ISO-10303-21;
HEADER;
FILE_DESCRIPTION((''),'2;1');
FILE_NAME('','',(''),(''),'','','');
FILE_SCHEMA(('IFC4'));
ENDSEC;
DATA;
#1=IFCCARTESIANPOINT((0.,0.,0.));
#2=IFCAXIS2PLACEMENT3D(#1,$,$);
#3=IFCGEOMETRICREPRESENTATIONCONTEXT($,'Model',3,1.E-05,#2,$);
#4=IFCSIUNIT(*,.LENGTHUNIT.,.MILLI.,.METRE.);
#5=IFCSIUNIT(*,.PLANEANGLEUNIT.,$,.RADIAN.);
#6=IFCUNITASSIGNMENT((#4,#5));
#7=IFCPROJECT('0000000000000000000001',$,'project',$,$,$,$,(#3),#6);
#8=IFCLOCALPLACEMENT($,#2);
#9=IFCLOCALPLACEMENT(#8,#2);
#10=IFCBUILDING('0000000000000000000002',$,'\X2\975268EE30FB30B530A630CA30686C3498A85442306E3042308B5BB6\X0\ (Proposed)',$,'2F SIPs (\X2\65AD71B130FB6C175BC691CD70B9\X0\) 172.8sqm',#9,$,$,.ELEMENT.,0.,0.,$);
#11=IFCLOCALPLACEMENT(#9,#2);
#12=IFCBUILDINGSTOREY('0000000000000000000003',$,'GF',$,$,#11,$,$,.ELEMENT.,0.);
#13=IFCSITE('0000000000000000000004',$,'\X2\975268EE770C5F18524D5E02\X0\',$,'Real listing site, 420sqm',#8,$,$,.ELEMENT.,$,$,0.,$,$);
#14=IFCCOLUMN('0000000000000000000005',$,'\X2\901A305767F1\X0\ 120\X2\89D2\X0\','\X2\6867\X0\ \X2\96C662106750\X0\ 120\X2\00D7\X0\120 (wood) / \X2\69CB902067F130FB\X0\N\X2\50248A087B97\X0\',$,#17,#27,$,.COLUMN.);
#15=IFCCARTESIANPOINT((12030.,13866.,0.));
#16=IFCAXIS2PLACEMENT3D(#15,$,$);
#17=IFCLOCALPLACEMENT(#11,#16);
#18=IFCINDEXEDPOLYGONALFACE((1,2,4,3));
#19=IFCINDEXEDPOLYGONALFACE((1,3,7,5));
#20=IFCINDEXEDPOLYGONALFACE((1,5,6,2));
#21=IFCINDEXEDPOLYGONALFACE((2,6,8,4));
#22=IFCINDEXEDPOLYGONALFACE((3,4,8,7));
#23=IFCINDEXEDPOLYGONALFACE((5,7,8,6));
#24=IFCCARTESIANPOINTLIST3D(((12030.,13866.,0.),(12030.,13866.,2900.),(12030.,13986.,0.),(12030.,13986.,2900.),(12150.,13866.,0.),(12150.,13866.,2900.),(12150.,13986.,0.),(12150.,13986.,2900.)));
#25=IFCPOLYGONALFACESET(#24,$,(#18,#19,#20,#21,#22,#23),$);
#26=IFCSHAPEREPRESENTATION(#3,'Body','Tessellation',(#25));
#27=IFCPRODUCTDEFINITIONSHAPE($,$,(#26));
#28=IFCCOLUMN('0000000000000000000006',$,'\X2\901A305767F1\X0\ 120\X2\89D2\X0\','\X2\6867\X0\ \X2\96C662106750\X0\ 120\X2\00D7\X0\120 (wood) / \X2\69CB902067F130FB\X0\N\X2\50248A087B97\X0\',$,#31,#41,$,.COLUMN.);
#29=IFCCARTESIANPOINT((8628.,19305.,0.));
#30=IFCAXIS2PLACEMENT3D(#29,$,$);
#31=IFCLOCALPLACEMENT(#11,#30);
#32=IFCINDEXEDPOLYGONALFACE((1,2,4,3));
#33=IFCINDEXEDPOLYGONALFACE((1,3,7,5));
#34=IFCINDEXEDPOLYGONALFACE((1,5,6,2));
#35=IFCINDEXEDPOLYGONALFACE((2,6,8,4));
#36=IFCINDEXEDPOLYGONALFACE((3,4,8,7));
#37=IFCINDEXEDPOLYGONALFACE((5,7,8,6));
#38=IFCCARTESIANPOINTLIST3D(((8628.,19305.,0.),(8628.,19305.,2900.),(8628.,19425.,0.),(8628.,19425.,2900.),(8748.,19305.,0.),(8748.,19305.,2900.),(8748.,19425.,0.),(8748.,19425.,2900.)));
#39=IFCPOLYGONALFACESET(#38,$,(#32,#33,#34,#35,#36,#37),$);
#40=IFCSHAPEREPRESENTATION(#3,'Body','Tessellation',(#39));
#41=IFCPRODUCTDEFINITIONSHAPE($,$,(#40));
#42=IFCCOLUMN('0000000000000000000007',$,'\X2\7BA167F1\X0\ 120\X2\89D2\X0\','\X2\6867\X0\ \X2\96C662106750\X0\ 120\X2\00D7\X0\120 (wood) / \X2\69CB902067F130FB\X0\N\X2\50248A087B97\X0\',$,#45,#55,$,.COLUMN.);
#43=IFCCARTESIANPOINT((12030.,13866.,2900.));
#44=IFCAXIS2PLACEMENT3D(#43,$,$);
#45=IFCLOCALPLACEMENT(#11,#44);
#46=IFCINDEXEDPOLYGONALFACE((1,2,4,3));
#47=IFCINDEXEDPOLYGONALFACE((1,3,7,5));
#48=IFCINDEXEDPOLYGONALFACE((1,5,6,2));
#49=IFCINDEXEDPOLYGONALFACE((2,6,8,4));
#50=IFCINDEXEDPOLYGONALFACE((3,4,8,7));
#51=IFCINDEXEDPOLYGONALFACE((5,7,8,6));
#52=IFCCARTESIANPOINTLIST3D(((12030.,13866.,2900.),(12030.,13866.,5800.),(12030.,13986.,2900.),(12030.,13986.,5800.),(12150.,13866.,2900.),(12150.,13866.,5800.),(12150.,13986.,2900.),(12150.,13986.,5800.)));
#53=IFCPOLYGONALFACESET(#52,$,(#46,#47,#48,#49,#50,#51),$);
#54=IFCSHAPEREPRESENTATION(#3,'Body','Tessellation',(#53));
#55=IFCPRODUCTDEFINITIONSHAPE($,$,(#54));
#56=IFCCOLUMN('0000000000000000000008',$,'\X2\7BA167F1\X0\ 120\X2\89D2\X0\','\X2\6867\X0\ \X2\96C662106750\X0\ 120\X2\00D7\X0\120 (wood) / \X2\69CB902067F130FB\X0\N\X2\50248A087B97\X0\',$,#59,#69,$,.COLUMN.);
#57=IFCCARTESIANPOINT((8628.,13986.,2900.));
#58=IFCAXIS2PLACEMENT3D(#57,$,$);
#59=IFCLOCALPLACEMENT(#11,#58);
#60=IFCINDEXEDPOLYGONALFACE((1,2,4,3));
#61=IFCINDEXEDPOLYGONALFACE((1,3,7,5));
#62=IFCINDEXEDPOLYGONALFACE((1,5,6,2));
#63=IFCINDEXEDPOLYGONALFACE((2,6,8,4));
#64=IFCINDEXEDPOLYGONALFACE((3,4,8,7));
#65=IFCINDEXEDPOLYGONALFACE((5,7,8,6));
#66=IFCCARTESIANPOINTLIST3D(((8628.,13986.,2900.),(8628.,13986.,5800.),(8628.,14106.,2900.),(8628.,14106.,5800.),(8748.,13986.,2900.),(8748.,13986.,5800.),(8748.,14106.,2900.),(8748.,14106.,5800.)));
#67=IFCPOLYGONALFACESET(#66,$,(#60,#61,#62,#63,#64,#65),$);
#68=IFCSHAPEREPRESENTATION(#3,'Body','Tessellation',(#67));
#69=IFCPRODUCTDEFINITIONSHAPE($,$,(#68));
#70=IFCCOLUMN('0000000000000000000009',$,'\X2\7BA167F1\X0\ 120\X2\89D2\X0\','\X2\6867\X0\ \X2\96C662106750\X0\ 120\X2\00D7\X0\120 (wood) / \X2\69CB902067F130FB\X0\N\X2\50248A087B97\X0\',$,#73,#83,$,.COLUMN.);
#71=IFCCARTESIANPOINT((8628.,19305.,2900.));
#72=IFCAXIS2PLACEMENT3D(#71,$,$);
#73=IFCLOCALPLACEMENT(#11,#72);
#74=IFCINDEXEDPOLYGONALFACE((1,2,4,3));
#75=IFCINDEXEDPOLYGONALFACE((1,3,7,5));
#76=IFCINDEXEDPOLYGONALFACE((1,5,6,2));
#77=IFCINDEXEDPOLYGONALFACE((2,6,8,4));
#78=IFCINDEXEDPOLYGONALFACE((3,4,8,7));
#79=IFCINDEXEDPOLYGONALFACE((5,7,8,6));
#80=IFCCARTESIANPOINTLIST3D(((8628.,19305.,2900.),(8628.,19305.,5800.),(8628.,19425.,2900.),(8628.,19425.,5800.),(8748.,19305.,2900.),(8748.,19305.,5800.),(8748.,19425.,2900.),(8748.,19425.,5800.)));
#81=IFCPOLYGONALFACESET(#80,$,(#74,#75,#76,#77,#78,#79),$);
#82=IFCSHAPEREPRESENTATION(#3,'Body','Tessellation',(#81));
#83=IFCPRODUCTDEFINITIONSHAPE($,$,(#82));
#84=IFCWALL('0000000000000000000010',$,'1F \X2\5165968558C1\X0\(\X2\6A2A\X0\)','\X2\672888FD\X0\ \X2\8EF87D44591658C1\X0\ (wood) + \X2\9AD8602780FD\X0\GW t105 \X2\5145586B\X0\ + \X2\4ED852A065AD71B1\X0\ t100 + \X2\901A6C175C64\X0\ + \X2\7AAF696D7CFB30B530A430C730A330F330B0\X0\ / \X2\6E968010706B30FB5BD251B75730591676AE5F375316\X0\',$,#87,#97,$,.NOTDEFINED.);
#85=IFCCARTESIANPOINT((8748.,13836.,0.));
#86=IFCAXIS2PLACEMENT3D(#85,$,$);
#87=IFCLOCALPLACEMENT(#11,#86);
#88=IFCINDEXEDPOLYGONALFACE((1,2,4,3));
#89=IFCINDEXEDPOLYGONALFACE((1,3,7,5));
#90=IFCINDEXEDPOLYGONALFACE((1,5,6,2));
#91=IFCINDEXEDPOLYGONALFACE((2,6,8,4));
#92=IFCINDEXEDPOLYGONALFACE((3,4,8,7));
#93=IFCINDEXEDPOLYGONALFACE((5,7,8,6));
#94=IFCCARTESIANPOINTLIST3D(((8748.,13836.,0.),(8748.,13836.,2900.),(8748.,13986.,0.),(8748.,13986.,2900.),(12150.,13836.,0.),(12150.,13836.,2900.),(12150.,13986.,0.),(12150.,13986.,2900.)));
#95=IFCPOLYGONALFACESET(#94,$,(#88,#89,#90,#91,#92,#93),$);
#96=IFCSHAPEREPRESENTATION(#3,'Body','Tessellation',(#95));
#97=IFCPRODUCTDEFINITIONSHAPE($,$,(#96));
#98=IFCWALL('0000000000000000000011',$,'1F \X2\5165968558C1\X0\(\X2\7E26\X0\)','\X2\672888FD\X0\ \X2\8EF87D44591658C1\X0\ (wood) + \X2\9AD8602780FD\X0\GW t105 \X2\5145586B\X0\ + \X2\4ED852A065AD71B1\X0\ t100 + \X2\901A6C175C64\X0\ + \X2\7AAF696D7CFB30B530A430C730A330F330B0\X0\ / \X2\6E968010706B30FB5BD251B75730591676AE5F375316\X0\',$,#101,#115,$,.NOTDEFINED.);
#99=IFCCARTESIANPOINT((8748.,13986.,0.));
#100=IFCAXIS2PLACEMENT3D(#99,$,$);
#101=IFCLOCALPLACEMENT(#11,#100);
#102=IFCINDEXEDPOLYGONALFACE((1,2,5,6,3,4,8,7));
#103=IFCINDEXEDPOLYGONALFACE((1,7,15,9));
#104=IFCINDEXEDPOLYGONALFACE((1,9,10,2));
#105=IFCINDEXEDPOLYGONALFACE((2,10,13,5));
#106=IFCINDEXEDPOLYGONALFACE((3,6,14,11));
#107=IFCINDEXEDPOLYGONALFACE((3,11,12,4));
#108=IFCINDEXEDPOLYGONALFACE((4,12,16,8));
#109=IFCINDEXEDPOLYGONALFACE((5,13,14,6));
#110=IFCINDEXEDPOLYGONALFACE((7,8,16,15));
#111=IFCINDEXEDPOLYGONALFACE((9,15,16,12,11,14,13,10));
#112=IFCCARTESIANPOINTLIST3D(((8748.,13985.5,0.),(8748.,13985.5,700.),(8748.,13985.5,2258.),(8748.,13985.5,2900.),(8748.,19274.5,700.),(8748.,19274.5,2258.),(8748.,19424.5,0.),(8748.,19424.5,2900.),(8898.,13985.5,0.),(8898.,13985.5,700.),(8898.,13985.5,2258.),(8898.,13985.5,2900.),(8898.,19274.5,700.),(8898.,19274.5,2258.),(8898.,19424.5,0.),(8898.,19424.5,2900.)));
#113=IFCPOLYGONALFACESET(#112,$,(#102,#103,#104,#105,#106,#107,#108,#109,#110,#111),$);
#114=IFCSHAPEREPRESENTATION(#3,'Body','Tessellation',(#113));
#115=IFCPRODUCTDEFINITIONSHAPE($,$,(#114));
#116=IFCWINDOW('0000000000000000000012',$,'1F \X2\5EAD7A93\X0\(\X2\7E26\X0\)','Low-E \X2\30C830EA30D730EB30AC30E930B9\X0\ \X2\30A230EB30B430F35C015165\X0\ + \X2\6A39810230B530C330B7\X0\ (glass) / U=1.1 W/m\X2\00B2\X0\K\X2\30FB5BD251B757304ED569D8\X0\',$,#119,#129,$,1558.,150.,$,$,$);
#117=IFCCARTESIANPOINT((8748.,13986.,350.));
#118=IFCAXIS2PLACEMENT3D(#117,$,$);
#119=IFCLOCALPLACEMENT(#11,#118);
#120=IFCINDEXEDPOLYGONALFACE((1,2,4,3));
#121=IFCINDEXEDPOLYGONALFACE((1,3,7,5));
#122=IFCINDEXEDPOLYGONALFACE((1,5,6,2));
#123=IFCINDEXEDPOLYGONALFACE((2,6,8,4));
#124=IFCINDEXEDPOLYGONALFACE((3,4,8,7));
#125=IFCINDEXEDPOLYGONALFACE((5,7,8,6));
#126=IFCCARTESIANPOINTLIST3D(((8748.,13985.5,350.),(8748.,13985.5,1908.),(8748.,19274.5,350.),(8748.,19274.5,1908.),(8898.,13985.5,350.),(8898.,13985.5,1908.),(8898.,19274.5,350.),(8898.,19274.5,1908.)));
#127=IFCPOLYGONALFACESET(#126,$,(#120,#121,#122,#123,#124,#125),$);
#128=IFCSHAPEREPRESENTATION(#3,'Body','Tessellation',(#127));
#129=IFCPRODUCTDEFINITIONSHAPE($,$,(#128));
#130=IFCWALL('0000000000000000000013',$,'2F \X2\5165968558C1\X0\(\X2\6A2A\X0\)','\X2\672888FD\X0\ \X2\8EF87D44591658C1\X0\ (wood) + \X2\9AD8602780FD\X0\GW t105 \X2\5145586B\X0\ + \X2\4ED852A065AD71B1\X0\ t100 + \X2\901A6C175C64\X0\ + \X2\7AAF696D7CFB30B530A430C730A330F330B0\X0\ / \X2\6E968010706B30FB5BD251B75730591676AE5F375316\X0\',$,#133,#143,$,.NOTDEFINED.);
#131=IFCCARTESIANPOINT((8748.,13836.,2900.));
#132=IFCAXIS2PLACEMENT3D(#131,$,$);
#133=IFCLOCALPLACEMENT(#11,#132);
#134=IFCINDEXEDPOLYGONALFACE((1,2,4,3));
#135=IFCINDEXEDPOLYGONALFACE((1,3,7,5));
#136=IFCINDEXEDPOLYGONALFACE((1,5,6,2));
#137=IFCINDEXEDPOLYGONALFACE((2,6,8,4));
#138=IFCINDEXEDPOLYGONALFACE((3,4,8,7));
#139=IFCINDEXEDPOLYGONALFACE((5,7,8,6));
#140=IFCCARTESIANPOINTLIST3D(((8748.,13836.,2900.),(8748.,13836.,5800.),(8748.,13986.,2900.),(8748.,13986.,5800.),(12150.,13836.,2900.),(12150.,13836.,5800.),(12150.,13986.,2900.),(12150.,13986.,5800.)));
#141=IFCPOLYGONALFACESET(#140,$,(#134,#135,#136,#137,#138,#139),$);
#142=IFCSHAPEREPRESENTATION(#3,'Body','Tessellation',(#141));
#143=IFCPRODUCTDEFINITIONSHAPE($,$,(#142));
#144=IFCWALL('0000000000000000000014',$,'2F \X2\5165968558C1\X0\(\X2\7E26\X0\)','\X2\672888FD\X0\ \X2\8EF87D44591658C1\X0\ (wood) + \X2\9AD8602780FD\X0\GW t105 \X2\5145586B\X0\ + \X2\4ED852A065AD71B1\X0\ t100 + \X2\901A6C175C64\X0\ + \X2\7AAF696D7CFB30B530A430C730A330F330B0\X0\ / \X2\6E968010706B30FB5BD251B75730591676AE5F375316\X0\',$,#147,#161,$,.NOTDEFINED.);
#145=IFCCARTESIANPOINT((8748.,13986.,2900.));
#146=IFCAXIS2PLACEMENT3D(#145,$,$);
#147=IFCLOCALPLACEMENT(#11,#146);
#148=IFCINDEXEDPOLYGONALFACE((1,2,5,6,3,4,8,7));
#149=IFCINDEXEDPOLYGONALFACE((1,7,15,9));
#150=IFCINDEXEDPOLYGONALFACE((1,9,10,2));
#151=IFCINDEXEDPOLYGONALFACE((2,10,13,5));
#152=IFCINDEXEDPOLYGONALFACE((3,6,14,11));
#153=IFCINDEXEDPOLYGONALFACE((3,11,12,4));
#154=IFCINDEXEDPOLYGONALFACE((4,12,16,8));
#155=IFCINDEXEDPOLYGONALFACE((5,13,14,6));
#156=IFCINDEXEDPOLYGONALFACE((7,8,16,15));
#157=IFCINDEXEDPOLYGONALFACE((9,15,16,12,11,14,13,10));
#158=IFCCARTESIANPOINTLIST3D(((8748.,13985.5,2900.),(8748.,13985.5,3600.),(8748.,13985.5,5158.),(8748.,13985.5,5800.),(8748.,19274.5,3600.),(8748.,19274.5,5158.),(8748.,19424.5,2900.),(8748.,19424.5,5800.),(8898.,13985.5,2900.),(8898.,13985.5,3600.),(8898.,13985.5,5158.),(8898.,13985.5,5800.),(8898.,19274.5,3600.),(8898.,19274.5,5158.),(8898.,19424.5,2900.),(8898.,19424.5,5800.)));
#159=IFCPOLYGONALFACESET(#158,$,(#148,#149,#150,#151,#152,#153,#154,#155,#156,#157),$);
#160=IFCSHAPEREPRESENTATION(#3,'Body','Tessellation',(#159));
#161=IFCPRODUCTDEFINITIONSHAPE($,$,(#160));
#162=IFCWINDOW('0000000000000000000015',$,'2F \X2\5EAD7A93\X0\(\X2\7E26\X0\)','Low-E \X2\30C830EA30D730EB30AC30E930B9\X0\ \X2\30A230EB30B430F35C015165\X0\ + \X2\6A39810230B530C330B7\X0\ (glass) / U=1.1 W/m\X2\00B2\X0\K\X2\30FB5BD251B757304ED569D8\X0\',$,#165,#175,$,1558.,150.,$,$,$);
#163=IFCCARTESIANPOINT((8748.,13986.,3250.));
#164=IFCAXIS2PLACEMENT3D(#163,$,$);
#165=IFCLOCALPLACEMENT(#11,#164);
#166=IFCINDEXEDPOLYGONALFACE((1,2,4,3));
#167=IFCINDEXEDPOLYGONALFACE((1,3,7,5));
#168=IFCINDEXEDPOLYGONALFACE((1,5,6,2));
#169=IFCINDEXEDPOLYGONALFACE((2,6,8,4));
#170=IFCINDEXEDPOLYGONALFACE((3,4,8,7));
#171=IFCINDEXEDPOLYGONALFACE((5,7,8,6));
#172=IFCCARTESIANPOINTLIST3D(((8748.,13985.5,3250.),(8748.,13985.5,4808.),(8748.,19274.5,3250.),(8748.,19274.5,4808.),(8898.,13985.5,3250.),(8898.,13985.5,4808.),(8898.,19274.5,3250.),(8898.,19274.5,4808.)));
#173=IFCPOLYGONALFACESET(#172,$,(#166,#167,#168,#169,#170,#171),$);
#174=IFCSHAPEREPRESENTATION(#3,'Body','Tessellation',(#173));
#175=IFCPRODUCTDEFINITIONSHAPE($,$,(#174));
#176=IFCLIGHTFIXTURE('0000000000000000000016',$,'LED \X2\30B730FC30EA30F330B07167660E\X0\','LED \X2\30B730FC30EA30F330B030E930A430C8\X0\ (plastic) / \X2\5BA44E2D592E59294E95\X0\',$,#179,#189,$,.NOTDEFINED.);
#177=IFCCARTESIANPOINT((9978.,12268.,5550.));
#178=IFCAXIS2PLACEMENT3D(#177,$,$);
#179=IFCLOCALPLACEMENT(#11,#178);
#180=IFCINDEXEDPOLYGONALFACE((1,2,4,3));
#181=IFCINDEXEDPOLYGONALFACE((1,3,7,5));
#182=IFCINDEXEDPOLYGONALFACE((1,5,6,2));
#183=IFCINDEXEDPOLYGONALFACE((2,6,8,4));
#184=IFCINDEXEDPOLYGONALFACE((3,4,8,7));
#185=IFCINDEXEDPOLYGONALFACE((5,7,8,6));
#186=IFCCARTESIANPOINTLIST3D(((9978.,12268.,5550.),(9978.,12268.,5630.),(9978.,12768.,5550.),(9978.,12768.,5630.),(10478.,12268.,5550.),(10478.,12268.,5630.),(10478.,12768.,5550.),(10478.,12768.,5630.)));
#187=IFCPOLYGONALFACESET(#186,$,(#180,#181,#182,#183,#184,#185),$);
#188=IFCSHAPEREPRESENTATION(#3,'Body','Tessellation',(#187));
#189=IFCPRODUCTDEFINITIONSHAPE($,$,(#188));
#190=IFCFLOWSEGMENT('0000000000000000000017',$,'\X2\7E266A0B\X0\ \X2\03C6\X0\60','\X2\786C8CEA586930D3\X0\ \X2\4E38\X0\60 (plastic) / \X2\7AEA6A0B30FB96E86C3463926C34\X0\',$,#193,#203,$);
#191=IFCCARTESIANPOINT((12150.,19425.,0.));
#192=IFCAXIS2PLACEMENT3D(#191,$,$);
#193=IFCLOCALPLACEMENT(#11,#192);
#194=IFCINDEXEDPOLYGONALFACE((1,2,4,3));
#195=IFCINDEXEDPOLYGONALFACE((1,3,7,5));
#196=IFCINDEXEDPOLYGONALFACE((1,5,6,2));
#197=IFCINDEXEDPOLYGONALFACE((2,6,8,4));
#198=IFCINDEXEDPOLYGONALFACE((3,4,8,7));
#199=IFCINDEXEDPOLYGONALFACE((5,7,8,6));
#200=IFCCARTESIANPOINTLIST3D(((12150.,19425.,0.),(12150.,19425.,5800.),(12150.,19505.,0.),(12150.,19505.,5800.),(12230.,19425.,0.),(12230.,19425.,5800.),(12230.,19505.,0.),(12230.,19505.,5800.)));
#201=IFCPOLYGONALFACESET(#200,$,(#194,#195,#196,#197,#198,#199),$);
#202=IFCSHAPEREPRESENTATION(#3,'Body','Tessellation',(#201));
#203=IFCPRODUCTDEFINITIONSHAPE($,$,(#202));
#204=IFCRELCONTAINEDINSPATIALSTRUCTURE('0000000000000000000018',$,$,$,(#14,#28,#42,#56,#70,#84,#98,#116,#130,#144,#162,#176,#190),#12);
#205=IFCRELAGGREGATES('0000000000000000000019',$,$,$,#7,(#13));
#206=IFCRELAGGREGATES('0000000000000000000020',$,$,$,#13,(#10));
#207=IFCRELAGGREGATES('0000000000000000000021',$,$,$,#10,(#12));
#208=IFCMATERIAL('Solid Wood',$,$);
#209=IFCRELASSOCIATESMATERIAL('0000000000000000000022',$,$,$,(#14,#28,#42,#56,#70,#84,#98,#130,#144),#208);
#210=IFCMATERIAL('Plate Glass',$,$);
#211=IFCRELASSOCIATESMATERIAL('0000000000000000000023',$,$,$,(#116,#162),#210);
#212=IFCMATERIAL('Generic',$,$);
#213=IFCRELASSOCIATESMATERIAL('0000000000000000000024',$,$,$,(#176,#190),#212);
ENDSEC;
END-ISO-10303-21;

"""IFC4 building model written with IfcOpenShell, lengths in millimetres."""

from ifc_helpers import new_model, si_unit, frame, frame_2d, origin, place, context, project, spatial, rectangle, extrude, material, element, fill, save


model = new_model("IFC4")

# Units and contexts
model_context = context("Model", 3, precision=1e-05, world=origin())
ifc_project = project(units=[si_unit("LENGTHUNIT", "METRE", prefix="MILLI"), si_unit("PLANEANGLEUNIT", "RADIAN")], contexts=[model_context])

# Site, building, storey
site_placement = place(None, origin())
site = spatial("IfcSite", under=ifc_project, at=site_placement, Name="青森県弘前市", ObjectType="Real listing site, 420sqm", CompositionType="ELEMENT", RefElevation=0.0)
building_placement = place(site_placement, origin())
building = spatial("IfcBuilding", under=site, at=building_placement, Name="青森・サウナと水風呂のある家 (Proposed)", ObjectType="2F SIPs (断熱・気密重点) 172.8sqm", CompositionType="ELEMENT", ElevationOfRefHeight=0.0, ElevationOfTerrain=0.0)
storey_placement = place(building_placement, origin())
storey = spatial("IfcBuildingStorey", under=building, at=storey_placement, Name="GF", CompositionType="ELEMENT", Elevation=0.0)

# Columns
ifc_material_1 = material(Name="Solid Wood")
column_1_placement = place(storey_placement, frame((12030.0, 13866.0, 0.0)))
element("IfcColumn", 1, at=column_1_placement, inside=storey, material=ifc_material_1, Name="通し柱 120角", Description="桧 集成材 120×120 (wood) / 構造柱・N値計算", PredefinedType="COLUMN", context=model_context, shape_type="SweptSolid", body=[
    extrude(rectangle(XDim=120.0, YDim=120.0, at=frame_2d((60.0, 60.0))), frame((12030.0, 13866.0, 0.0)), (0.0, 0.0, 1.0), 2900.0),
])
column_2_placement = place(storey_placement, frame((8628.0, 19305.0, 0.0)))
element("IfcColumn", 2, at=column_2_placement, inside=storey, material=ifc_material_1, Name="通し柱 120角", Description="桧 集成材 120×120 (wood) / 構造柱・N値計算", PredefinedType="COLUMN", context=model_context, shape_type="SweptSolid", body=[
    extrude(rectangle(XDim=120.0, YDim=120.0, at=frame_2d((60.0, 60.0))), frame((8628.0, 19305.0, 0.0)), (0.0, 0.0, 1.0), 2900.0),
])
column_3_placement = place(storey_placement, frame((12030.0, 13866.0, 2900.0)))
element("IfcColumn", 3, at=column_3_placement, inside=storey, material=ifc_material_1, Name="管柱 120角", Description="桧 集成材 120×120 (wood) / 構造柱・N値計算", PredefinedType="COLUMN", context=model_context, shape_type="SweptSolid", body=[
    extrude(rectangle(XDim=120.0, YDim=120.0, at=frame_2d((60.0, 60.0))), frame((12030.0, 13866.0, 2900.0)), (0.0, 0.0, 1.0), 2900.0),
])
column_4_placement = place(storey_placement, frame((8628.0, 13986.0, 2900.0)))
element("IfcColumn", 4, at=column_4_placement, inside=storey, material=ifc_material_1, Name="管柱 120角", Description="桧 集成材 120×120 (wood) / 構造柱・N値計算", PredefinedType="COLUMN", context=model_context, shape_type="SweptSolid", body=[
    extrude(rectangle(XDim=120.0, YDim=120.0, at=frame_2d((60.0, 60.0))), frame((8628.0, 13986.0, 2900.0)), (0.0, 0.0, 1.0), 2900.0),
])
column_5_placement = place(storey_placement, frame((8628.0, 19305.0, 2900.0)))
element("IfcColumn", 5, at=column_5_placement, inside=storey, material=ifc_material_1, Name="管柱 120角", Description="桧 集成材 120×120 (wood) / 構造柱・N値計算", PredefinedType="COLUMN", context=model_context, shape_type="SweptSolid", body=[
    extrude(rectangle(XDim=120.0, YDim=120.0, at=frame_2d((60.0, 60.0))), frame((8628.0, 19305.0, 2900.0)), (0.0, 0.0, 1.0), 2900.0),
])

# Wall
wall_1_placement = place(storey_placement, frame((8748.0, 13836.0, 0.0)))
element("IfcWall", 6, at=wall_1_placement, inside=storey, material=ifc_material_1, Name="1F 入隅壁(横)", Description="木製 軸組外壁 (wood) + 高性能GW t105 充填 + 付加断熱 t100 + 通気層 + 窯業系サイディング / 準耐火・寒冷地外皮強化", PredefinedType="NOTDEFINED", context=model_context, shape_type="SweptSolid", body=[
    extrude(rectangle(XDim=3402.0, YDim=150.0, at=frame_2d((1701.0, 75.0))), frame((8748.0, 13836.0, 0.0)), (0.0, 0.0, 1.0), 2900.0),
])

# Wall, opening, window
wall_2_placement = place(storey_placement, frame((8748.0, 13986.0, 0.0)))
wall_2 = element("IfcWall", 7, at=wall_2_placement, inside=storey, material=ifc_material_1, Name="1F 入隅壁(縦)", Description="木製 軸組外壁 (wood) + 高性能GW t105 充填 + 付加断熱 t100 + 通気層 + 窯業系サイディング / 準耐火・寒冷地外皮強化", PredefinedType="NOTDEFINED", context=model_context, shape_type="SweptSolid", body=[
    extrude(rectangle(XDim=150.0, YDim=5439.0, at=frame_2d((75.0, 2719.0))), frame((8748.0, 13986.0, 0.0)), (0.0, 0.0, 1.0), 2900.0),
])
opening_1_placement = place(storey_placement, frame((8748.0, 13986.0, 350.0)))
opening_1 = element("IfcOpeningElement", 8, at=opening_1_placement, cuts=wall_2, PredefinedType="NOTDEFINED", context=model_context, shape_type="SweptSolid", body=[
    extrude(rectangle(XDim=150.0, YDim=5289.0, at=frame_2d((75.0, 2644.0))), frame((8748.0, 13986.0, 350.0)), (0.0, 0.0, 1.0), 1558.0),
])
ifc_material_2 = material(Name="Plate Glass")
window_1_placement = place(storey_placement, frame((8748.0, 13986.0, 350.0)))
window_1 = element("IfcWindow", 9, at=window_1_placement, inside=storey, material=ifc_material_2, Name="1F 庭窓(縦)", Description="Low-E トリプルガラス アルゴン封入 + 樹脂サッシ (glass) / U=1.1 W/m²K・寒冷地仕様", OverallHeight=1558.0, OverallWidth=150.0, context=model_context, shape_type="SweptSolid", body=[
    extrude(rectangle(XDim=150.0, YDim=5289.0, at=frame_2d((75.0, 2644.0))), frame((8748.0, 13986.0, 350.0)), (0.0, 0.0, 1.0), 1558.0),
])
fill(opening_1, window_1)

# Wall
wall_3_placement = place(storey_placement, frame((8748.0, 13836.0, 2900.0)))
element("IfcWall", 10, at=wall_3_placement, inside=storey, material=ifc_material_1, Name="2F 入隅壁(横)", Description="木製 軸組外壁 (wood) + 高性能GW t105 充填 + 付加断熱 t100 + 通気層 + 窯業系サイディング / 準耐火・寒冷地外皮強化", PredefinedType="NOTDEFINED", context=model_context, shape_type="SweptSolid", body=[
    extrude(rectangle(XDim=3402.0, YDim=150.0, at=frame_2d((1701.0, 75.0))), frame((8748.0, 13836.0, 2900.0)), (0.0, 0.0, 1.0), 2900.0),
])

# Wall, opening, window
wall_4_placement = place(storey_placement, frame((8748.0, 13986.0, 2900.0)))
wall_4 = element("IfcWall", 11, at=wall_4_placement, inside=storey, material=ifc_material_1, Name="2F 入隅壁(縦)", Description="木製 軸組外壁 (wood) + 高性能GW t105 充填 + 付加断熱 t100 + 通気層 + 窯業系サイディング / 準耐火・寒冷地外皮強化", PredefinedType="NOTDEFINED", context=model_context, shape_type="SweptSolid", body=[
    extrude(rectangle(XDim=150.0, YDim=5439.0, at=frame_2d((75.0, 2719.0))), frame((8748.0, 13986.0, 2900.0)), (0.0, 0.0, 1.0), 2900.0),
])
opening_2_placement = place(storey_placement, frame((8748.0, 13986.0, 3250.0)))
opening_2 = element("IfcOpeningElement", 12, at=opening_2_placement, cuts=wall_4, PredefinedType="NOTDEFINED", context=model_context, shape_type="SweptSolid", body=[
    extrude(rectangle(XDim=150.0, YDim=5289.0, at=frame_2d((75.0, 2644.0))), frame((8748.0, 13986.0, 3250.0)), (0.0, 0.0, 1.0), 1558.0),
])
window_2_placement = place(storey_placement, frame((8748.0, 13986.0, 3250.0)))
window_2 = element("IfcWindow", 13, at=window_2_placement, inside=storey, material=ifc_material_2, Name="2F 庭窓(縦)", Description="Low-E トリプルガラス アルゴン封入 + 樹脂サッシ (glass) / U=1.1 W/m²K・寒冷地仕様", OverallHeight=1558.0, OverallWidth=150.0, context=model_context, shape_type="SweptSolid", body=[
    extrude(rectangle(XDim=150.0, YDim=5289.0, at=frame_2d((75.0, 2644.0))), frame((8748.0, 13986.0, 3250.0)), (0.0, 0.0, 1.0), 1558.0),
])
fill(opening_2, window_2)

# Light fixture
ifc_material_3 = material(Name="Generic")
light_fixture_placement = place(storey_placement, frame((9978.0, 12268.0, 5550.0)))
element("IfcLightFixture", 14, at=light_fixture_placement, inside=storey, material=ifc_material_3, Name="LED シーリング照明", Description="LED シーリングライト (plastic) / 室中央天井", PredefinedType="NOTDEFINED", context=model_context, shape_type="SweptSolid", body=[
    extrude(rectangle(XDim=500.0, YDim=500.0, at=frame_2d((250.0, 250.0))), frame((9978.0, 12268.0, 5550.0)), (0.0, 0.0, 1.0), 80.0),
])

# Flow segment
flow_segment_placement = place(storey_placement, frame((12150.0, 19425.0, 0.0)))
element("IfcFlowSegment", 15, at=flow_segment_placement, inside=storey, material=ifc_material_3, Name="縦樋 φ60", Description="硬質塩ビ 丸60 (plastic) / 竪樋・雨水排水", context=model_context, shape_type="SweptSolid", body=[
    extrude(rectangle(XDim=80.0, YDim=80.0, at=frame_2d((40.0, 40.0))), frame((12150.0, 19425.0, 0.0)), (0.0, 0.0, 1.0), 5800.0),
])

save(model, "model.ifc")
